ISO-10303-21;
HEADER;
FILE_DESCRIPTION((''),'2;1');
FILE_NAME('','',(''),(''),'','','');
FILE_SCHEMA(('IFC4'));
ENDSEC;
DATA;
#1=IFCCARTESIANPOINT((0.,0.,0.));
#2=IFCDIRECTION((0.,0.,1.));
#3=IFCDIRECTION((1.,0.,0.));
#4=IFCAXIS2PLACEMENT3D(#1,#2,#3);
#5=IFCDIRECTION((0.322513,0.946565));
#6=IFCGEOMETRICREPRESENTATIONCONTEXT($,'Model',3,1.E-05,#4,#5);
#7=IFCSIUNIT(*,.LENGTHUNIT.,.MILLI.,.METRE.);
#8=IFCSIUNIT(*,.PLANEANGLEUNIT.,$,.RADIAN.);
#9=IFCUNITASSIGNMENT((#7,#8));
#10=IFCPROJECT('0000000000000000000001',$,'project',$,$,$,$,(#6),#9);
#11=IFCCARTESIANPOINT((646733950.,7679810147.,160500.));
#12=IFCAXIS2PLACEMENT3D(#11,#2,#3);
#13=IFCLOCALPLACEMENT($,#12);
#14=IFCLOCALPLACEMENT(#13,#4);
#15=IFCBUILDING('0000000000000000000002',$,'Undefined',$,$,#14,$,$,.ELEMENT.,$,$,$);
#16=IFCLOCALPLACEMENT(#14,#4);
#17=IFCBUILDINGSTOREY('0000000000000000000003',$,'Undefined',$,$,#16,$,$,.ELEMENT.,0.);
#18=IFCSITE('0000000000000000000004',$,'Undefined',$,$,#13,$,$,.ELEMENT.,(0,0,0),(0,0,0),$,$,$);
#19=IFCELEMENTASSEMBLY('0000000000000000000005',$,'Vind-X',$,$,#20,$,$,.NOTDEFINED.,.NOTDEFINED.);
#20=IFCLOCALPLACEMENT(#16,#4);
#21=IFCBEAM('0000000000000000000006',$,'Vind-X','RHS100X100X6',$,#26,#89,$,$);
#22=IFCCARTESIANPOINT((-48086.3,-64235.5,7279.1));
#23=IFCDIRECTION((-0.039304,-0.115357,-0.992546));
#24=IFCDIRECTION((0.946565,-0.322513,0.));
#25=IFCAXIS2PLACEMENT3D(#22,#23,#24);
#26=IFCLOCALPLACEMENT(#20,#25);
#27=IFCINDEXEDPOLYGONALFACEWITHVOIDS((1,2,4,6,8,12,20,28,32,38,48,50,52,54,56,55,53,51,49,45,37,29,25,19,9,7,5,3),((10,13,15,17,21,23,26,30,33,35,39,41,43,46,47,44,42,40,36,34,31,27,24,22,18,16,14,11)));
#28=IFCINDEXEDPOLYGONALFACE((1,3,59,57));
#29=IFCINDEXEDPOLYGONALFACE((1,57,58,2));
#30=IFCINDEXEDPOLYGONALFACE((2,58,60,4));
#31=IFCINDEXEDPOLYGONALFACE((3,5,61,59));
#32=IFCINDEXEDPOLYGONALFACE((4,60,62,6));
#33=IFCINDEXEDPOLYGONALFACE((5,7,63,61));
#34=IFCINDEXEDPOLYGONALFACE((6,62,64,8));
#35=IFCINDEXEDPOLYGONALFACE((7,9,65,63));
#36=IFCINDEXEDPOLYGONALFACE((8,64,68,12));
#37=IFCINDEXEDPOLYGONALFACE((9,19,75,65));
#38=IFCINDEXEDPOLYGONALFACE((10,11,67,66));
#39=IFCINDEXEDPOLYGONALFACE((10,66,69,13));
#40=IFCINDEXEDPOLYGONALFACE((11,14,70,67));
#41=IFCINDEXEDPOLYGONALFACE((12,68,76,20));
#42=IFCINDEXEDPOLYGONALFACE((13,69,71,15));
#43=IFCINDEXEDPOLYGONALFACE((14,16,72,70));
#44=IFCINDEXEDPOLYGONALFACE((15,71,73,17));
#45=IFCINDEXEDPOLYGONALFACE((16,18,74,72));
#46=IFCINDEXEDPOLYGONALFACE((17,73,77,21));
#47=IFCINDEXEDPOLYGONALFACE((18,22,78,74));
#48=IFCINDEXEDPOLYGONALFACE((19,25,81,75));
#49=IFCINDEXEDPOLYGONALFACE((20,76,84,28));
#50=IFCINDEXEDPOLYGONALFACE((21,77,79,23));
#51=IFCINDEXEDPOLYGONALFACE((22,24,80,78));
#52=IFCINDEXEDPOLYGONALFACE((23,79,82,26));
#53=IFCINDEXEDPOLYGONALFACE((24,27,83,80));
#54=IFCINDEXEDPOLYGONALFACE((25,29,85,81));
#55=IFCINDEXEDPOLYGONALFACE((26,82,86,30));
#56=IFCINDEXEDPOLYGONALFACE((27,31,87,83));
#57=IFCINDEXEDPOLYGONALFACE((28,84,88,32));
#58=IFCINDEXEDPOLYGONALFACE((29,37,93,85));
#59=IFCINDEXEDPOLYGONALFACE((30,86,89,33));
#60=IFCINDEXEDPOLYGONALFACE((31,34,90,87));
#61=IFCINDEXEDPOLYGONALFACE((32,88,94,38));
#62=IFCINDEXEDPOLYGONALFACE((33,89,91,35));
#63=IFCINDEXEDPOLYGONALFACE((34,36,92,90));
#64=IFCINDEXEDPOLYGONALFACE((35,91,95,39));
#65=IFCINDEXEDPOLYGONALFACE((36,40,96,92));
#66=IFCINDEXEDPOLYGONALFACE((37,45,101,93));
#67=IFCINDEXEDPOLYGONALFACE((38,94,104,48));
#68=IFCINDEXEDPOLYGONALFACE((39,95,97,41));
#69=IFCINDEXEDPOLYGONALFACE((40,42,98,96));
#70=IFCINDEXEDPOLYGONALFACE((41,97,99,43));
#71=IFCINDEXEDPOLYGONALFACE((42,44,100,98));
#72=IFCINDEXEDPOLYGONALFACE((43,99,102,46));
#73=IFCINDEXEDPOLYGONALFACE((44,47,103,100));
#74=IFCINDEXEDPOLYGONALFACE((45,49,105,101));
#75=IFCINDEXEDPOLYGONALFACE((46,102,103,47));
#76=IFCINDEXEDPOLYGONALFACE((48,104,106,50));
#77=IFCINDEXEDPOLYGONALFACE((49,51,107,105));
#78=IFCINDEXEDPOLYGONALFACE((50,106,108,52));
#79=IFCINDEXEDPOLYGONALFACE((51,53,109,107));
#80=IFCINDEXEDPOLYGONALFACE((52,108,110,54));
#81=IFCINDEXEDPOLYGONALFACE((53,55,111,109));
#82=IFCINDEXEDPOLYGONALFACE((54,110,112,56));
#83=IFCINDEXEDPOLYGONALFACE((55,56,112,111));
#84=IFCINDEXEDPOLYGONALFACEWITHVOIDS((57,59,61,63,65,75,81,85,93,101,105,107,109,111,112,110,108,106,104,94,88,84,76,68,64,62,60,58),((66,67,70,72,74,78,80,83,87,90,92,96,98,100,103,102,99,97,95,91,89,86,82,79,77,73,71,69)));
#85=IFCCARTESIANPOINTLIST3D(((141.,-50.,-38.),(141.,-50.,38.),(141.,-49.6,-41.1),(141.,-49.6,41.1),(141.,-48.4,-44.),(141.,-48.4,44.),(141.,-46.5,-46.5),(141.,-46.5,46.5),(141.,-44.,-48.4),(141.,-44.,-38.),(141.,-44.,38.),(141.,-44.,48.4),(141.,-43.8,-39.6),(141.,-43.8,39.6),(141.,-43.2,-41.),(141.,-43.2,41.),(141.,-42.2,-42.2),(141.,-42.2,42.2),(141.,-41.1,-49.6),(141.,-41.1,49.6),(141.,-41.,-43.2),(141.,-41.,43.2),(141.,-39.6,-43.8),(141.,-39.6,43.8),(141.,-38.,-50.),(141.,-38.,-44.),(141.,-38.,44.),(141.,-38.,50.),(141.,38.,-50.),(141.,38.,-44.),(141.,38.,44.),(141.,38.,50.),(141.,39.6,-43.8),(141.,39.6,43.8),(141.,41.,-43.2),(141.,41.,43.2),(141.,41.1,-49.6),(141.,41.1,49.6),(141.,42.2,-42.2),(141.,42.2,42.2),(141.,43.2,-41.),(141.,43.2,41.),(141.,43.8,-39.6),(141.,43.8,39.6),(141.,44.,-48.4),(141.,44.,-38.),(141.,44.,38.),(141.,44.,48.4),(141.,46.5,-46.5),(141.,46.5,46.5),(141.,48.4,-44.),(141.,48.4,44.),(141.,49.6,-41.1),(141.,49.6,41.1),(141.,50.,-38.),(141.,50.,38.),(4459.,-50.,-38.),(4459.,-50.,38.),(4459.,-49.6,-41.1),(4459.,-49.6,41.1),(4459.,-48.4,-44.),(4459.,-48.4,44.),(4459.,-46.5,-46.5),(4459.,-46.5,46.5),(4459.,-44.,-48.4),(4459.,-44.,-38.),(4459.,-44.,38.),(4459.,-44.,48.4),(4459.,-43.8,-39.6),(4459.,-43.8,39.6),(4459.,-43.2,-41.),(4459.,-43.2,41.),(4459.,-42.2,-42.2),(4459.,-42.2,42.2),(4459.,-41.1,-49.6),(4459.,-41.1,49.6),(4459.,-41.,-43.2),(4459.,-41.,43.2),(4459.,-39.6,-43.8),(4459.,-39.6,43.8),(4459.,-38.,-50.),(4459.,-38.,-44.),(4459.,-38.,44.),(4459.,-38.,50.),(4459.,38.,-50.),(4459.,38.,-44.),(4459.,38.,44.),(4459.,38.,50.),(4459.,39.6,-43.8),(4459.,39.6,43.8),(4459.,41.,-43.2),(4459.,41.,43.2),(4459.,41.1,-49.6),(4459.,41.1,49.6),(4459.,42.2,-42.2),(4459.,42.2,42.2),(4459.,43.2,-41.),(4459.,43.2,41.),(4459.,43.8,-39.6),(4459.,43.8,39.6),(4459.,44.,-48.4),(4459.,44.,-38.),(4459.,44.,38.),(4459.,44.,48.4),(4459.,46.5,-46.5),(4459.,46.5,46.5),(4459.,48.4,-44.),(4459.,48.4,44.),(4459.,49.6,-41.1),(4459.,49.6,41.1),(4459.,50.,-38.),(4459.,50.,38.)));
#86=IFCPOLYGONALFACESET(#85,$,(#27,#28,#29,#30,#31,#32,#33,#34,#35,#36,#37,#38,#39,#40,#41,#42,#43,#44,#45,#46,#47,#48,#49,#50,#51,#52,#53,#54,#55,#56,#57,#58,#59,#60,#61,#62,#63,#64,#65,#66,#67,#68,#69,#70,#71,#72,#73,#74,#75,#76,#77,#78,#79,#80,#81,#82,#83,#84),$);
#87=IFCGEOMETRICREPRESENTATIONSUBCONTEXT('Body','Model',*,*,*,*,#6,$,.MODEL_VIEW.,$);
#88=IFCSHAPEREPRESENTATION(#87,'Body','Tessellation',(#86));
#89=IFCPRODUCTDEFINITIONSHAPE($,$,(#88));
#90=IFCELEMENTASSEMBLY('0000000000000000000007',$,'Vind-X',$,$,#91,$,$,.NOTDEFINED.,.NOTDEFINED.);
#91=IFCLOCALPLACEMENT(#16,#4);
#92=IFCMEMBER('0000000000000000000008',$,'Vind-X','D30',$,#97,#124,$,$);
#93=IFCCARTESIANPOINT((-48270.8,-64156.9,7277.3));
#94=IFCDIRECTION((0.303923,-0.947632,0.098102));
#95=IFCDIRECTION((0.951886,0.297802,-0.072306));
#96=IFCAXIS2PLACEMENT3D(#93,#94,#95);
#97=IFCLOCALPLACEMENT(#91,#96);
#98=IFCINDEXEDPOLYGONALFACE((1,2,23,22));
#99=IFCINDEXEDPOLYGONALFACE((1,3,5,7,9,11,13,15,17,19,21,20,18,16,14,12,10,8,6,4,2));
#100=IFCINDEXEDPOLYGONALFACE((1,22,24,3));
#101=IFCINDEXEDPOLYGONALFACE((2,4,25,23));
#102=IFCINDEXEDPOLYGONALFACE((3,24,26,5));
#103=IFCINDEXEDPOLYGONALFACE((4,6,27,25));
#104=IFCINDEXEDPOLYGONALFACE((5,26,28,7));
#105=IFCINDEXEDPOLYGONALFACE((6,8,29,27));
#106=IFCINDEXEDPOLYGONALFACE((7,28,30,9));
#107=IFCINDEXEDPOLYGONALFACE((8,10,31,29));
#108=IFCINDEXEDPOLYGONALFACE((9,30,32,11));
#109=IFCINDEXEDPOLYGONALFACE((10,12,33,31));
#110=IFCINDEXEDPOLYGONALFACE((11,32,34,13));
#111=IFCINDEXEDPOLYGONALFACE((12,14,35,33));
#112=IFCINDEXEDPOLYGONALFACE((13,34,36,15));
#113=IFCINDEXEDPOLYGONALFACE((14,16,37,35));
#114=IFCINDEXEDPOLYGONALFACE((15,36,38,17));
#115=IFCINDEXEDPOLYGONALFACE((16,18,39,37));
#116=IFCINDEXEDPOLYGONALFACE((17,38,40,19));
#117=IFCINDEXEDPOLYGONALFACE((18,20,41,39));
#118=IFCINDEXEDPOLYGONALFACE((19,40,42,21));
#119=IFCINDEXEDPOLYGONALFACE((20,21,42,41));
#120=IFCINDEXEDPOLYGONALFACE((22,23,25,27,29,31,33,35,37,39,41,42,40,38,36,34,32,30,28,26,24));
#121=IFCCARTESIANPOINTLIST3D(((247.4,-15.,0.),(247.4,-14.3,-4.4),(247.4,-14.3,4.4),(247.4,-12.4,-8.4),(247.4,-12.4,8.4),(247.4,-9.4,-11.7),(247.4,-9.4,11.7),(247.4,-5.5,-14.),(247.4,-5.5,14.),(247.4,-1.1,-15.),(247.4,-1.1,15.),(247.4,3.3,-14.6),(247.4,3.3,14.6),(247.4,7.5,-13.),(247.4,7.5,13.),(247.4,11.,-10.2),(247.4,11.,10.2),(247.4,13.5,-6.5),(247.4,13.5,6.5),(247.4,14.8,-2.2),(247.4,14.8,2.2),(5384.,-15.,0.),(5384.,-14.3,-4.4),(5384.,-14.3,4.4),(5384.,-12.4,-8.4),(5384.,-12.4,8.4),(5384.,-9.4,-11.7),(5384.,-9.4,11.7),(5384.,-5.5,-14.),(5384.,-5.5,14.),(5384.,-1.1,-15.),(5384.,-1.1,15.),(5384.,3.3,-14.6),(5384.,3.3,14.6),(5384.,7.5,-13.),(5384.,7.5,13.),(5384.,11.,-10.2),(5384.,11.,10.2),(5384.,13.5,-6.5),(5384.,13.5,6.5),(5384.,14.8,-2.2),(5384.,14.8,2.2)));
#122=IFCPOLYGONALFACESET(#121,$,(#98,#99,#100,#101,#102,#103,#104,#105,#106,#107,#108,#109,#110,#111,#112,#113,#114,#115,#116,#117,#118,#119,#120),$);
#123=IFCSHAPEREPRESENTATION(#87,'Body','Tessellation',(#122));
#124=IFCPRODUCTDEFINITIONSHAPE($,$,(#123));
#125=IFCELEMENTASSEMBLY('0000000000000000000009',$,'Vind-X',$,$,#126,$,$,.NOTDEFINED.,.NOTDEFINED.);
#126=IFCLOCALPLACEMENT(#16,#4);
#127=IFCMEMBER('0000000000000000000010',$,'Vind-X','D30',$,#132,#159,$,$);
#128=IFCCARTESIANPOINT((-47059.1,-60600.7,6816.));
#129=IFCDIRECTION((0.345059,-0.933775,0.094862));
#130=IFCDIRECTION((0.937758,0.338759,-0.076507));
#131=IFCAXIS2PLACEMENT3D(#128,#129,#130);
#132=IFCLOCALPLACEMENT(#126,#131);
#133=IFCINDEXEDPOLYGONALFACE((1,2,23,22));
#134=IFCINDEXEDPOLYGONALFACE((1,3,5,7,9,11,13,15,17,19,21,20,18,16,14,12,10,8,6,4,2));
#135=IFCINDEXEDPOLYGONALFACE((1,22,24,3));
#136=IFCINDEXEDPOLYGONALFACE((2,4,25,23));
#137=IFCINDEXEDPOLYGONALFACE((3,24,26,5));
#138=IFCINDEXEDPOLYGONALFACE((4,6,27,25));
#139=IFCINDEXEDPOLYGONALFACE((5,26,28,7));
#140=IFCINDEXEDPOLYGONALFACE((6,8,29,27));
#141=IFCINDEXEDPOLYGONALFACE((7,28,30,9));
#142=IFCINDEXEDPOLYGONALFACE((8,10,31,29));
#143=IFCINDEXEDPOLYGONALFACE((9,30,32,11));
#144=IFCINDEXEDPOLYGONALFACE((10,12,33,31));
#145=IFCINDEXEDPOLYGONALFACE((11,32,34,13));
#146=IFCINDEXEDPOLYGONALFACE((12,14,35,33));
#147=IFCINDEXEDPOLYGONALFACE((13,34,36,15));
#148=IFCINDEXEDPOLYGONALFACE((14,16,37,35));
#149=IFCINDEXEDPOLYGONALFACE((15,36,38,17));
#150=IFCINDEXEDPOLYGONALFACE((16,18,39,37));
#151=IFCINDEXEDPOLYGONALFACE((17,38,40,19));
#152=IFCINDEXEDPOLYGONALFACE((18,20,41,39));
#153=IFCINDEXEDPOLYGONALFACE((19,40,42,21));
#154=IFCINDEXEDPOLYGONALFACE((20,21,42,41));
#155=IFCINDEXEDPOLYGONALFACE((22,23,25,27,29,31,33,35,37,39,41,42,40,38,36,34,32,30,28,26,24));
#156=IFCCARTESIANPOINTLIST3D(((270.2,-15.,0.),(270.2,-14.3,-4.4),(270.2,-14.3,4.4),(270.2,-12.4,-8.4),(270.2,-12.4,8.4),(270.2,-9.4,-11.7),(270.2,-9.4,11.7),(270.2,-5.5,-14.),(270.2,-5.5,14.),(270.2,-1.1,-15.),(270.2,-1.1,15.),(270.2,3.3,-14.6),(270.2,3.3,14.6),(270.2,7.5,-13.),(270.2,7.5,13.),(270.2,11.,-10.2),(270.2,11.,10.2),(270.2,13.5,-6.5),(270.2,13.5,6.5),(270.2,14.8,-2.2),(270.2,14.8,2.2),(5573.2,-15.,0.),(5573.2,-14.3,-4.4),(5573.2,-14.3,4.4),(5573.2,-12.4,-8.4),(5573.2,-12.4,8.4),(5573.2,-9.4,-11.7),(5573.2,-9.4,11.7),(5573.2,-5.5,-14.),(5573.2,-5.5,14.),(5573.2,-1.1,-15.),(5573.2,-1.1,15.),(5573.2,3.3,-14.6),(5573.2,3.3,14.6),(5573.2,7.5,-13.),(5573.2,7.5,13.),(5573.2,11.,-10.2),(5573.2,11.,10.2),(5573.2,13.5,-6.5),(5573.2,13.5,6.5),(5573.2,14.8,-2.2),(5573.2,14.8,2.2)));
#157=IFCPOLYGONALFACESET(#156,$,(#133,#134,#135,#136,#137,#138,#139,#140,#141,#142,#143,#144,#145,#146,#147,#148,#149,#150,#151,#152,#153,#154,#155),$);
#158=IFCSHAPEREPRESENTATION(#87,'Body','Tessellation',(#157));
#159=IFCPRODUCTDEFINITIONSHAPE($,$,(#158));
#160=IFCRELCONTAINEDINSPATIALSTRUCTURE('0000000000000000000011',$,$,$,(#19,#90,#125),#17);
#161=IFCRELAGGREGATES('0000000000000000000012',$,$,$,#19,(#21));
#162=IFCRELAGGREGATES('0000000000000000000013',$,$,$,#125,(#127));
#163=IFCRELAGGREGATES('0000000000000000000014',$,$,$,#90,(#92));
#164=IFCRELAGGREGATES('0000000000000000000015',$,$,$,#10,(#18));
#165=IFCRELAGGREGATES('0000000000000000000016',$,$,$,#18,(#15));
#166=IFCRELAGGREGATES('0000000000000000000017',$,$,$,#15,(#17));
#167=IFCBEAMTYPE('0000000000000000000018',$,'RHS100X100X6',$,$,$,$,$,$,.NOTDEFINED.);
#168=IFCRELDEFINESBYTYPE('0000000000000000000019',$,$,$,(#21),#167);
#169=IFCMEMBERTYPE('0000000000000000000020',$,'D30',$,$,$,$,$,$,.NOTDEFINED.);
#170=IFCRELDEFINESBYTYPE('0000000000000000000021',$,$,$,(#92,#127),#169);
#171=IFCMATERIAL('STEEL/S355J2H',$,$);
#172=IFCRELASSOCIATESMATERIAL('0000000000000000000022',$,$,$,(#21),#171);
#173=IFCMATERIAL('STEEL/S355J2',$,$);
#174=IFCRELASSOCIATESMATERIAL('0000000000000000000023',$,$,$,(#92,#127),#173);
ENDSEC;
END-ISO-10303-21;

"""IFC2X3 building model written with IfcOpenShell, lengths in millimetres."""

from ifc_helpers import new_model, si_unit, direction, frame, origin_with_axes, origin_2d_with_axis, place, context, subcontext, project, spatial, hollow_rectangle, circle, extrude, clip, halfspace, material, type_object, element, aggregate, save


model = new_model("IFC2X3")

# Units and contexts
model_context = context("Model", 3, precision=1e-05, world=origin_with_axes(), true_north=direction((0.322513, 0.946565)))
body_context = subcontext(model_context, "Body", "Model", "MODEL_VIEW")
ifc_project = project(units=[si_unit("LENGTHUNIT", "METRE", prefix="MILLI"), si_unit("PLANEANGLEUNIT", "RADIAN")], contexts=[model_context])

# Site, building, storey
site_placement = place(None, frame((646733950.0, 7679810147.0, 160500.0), z_axis=(0.0, 0.0, 1.0), x_axis=(1.0, 0.0, 0.0)))
site = spatial("IfcSite", under=ifc_project, at=site_placement, Name="Undefined", CompositionType="ELEMENT", RefLatitude=(0, 0, 0), RefLongitude=(0, 0, 0))
building_placement = place(site_placement, origin_with_axes())
building = spatial("IfcBuilding", under=site, at=building_placement, Name="Undefined", CompositionType="ELEMENT")
storey_placement = place(building_placement, origin_with_axes())
storey = spatial("IfcBuildingStorey", under=building, at=storey_placement, Name="Undefined", CompositionType="ELEMENT", Elevation=0.0)

# Element assembly, beam
assembly_1_placement = place(storey_placement, origin_with_axes())
assembly_1 = element("IfcElementAssembly", 1, at=assembly_1_placement, inside=storey, Name="Vind-X", AssemblyPlace="NOTDEFINED", PredefinedType="NOTDEFINED")
ifc_material_1 = material(Name="STEEL/S355J2H")
beam_type_1 = type_object("IfcBeamType", Name="RHS100X100X6", PredefinedType="NOTDEFINED")
beam_1_placement = place(assembly_1_placement, frame((-48086.3, -64235.5, 7279.1), z_axis=(-0.039304, -0.115357, -0.992546), x_axis=(0.946565, -0.322513, 0.0)))
beam_1 = element("IfcBeam", 2, at=beam_1_placement, type_object=beam_type_1, material=ifc_material_1, Name="Vind-X", Description="RHS100X100X6", context=body_context, shape_type="Clipping", body=[
    clip(clip(extrude(hollow_rectangle(XDim=100.0, YDim=100.0, WallThickness=6.0, InnerFilletRadius=6.0, OuterFilletRadius=12.0, at=origin_2d_with_axis()), frame((4800.0, 0.0, 0.0), z_axis=(-1.0, 0.0, 0.0), x_axis=(0.0, -1.0, 0.0)), (0.0, 0.0, 1.0), 4800.0), halfspace(frame((4459.0, -22.5, 0.0), z_axis=(-1.0, 0.0, 0.0), x_axis=(0.0, 0.0, -1.0)), True)), halfspace(frame((141.0, -22.5, 0.0), z_axis=(1.0, 0.0, 0.0), x_axis=(0.0, 0.0, 1.0)), True)),
])

# Element assemblies, members
assembly_2_placement = place(storey_placement, origin_with_axes())
assembly_2 = element("IfcElementAssembly", 3, at=assembly_2_placement, inside=storey, Name="Vind-X", AssemblyPlace="NOTDEFINED", PredefinedType="NOTDEFINED")
ifc_material_2 = material(Name="STEEL/S355J2")
member_type_1 = type_object("IfcMemberType", Name="D30", PredefinedType="NOTDEFINED")
member_1_placement = place(assembly_2_placement, frame((-48270.8, -64156.9, 7277.3), z_axis=(0.303923, -0.947632, 0.098102), x_axis=(0.951886, 0.297802, -0.072306)))
member_1 = element("IfcMember", 4, at=member_1_placement, type_object=member_type_1, material=ifc_material_2, Name="Vind-X", Description="D30", context=body_context, shape_type="Clipping", body=[
    clip(extrude(circle(Radius=15.0, at=origin_2d_with_axis()), frame((5384.0, 0.0, 0.0), z_axis=(-1.0, 0.0, 0.0), x_axis=(0.0, -1.0, 0.0)), (0.0, 0.0, 1.0), 5384.0), halfspace(frame((247.4, -22.5, 0.0), z_axis=(1.0, 0.0, 0.0), x_axis=(0.0, 0.0, 1.0)), True)),
])
assembly_3_placement = place(storey_placement, origin_with_axes())
assembly_3 = element("IfcElementAssembly", 5, at=assembly_3_placement, inside=storey, Name="Vind-X", AssemblyPlace="NOTDEFINED", PredefinedType="NOTDEFINED")
member_2_placement = place(assembly_3_placement, frame((-47059.1, -60600.7, 6816.0), z_axis=(0.345059, -0.933775, 0.094862), x_axis=(0.937758, 0.338759, -0.076507)))
member_2 = element("IfcMember", 6, at=member_2_placement, type_object=member_type_1, material=ifc_material_2, Name="Vind-X", Description="D30", context=body_context, shape_type="Clipping", body=[
    clip(extrude(circle(Radius=15.0, at=origin_2d_with_axis()), frame((5573.2, 0.0, 0.0), z_axis=(-1.0, 0.0, 0.0), x_axis=(0.0, -1.0, 0.0)), (0.0, 0.0, 1.0), 5573.2), halfspace(frame((270.2, -22.5, 0.0), z_axis=(1.0, 0.0, 0.0), x_axis=(0.0, 0.0, 1.0)), True)),
])

aggregate(assembly_1, [beam_1])
aggregate(assembly_3, [member_2])
aggregate(assembly_2, [member_1])

save(model, "model.ifc")
